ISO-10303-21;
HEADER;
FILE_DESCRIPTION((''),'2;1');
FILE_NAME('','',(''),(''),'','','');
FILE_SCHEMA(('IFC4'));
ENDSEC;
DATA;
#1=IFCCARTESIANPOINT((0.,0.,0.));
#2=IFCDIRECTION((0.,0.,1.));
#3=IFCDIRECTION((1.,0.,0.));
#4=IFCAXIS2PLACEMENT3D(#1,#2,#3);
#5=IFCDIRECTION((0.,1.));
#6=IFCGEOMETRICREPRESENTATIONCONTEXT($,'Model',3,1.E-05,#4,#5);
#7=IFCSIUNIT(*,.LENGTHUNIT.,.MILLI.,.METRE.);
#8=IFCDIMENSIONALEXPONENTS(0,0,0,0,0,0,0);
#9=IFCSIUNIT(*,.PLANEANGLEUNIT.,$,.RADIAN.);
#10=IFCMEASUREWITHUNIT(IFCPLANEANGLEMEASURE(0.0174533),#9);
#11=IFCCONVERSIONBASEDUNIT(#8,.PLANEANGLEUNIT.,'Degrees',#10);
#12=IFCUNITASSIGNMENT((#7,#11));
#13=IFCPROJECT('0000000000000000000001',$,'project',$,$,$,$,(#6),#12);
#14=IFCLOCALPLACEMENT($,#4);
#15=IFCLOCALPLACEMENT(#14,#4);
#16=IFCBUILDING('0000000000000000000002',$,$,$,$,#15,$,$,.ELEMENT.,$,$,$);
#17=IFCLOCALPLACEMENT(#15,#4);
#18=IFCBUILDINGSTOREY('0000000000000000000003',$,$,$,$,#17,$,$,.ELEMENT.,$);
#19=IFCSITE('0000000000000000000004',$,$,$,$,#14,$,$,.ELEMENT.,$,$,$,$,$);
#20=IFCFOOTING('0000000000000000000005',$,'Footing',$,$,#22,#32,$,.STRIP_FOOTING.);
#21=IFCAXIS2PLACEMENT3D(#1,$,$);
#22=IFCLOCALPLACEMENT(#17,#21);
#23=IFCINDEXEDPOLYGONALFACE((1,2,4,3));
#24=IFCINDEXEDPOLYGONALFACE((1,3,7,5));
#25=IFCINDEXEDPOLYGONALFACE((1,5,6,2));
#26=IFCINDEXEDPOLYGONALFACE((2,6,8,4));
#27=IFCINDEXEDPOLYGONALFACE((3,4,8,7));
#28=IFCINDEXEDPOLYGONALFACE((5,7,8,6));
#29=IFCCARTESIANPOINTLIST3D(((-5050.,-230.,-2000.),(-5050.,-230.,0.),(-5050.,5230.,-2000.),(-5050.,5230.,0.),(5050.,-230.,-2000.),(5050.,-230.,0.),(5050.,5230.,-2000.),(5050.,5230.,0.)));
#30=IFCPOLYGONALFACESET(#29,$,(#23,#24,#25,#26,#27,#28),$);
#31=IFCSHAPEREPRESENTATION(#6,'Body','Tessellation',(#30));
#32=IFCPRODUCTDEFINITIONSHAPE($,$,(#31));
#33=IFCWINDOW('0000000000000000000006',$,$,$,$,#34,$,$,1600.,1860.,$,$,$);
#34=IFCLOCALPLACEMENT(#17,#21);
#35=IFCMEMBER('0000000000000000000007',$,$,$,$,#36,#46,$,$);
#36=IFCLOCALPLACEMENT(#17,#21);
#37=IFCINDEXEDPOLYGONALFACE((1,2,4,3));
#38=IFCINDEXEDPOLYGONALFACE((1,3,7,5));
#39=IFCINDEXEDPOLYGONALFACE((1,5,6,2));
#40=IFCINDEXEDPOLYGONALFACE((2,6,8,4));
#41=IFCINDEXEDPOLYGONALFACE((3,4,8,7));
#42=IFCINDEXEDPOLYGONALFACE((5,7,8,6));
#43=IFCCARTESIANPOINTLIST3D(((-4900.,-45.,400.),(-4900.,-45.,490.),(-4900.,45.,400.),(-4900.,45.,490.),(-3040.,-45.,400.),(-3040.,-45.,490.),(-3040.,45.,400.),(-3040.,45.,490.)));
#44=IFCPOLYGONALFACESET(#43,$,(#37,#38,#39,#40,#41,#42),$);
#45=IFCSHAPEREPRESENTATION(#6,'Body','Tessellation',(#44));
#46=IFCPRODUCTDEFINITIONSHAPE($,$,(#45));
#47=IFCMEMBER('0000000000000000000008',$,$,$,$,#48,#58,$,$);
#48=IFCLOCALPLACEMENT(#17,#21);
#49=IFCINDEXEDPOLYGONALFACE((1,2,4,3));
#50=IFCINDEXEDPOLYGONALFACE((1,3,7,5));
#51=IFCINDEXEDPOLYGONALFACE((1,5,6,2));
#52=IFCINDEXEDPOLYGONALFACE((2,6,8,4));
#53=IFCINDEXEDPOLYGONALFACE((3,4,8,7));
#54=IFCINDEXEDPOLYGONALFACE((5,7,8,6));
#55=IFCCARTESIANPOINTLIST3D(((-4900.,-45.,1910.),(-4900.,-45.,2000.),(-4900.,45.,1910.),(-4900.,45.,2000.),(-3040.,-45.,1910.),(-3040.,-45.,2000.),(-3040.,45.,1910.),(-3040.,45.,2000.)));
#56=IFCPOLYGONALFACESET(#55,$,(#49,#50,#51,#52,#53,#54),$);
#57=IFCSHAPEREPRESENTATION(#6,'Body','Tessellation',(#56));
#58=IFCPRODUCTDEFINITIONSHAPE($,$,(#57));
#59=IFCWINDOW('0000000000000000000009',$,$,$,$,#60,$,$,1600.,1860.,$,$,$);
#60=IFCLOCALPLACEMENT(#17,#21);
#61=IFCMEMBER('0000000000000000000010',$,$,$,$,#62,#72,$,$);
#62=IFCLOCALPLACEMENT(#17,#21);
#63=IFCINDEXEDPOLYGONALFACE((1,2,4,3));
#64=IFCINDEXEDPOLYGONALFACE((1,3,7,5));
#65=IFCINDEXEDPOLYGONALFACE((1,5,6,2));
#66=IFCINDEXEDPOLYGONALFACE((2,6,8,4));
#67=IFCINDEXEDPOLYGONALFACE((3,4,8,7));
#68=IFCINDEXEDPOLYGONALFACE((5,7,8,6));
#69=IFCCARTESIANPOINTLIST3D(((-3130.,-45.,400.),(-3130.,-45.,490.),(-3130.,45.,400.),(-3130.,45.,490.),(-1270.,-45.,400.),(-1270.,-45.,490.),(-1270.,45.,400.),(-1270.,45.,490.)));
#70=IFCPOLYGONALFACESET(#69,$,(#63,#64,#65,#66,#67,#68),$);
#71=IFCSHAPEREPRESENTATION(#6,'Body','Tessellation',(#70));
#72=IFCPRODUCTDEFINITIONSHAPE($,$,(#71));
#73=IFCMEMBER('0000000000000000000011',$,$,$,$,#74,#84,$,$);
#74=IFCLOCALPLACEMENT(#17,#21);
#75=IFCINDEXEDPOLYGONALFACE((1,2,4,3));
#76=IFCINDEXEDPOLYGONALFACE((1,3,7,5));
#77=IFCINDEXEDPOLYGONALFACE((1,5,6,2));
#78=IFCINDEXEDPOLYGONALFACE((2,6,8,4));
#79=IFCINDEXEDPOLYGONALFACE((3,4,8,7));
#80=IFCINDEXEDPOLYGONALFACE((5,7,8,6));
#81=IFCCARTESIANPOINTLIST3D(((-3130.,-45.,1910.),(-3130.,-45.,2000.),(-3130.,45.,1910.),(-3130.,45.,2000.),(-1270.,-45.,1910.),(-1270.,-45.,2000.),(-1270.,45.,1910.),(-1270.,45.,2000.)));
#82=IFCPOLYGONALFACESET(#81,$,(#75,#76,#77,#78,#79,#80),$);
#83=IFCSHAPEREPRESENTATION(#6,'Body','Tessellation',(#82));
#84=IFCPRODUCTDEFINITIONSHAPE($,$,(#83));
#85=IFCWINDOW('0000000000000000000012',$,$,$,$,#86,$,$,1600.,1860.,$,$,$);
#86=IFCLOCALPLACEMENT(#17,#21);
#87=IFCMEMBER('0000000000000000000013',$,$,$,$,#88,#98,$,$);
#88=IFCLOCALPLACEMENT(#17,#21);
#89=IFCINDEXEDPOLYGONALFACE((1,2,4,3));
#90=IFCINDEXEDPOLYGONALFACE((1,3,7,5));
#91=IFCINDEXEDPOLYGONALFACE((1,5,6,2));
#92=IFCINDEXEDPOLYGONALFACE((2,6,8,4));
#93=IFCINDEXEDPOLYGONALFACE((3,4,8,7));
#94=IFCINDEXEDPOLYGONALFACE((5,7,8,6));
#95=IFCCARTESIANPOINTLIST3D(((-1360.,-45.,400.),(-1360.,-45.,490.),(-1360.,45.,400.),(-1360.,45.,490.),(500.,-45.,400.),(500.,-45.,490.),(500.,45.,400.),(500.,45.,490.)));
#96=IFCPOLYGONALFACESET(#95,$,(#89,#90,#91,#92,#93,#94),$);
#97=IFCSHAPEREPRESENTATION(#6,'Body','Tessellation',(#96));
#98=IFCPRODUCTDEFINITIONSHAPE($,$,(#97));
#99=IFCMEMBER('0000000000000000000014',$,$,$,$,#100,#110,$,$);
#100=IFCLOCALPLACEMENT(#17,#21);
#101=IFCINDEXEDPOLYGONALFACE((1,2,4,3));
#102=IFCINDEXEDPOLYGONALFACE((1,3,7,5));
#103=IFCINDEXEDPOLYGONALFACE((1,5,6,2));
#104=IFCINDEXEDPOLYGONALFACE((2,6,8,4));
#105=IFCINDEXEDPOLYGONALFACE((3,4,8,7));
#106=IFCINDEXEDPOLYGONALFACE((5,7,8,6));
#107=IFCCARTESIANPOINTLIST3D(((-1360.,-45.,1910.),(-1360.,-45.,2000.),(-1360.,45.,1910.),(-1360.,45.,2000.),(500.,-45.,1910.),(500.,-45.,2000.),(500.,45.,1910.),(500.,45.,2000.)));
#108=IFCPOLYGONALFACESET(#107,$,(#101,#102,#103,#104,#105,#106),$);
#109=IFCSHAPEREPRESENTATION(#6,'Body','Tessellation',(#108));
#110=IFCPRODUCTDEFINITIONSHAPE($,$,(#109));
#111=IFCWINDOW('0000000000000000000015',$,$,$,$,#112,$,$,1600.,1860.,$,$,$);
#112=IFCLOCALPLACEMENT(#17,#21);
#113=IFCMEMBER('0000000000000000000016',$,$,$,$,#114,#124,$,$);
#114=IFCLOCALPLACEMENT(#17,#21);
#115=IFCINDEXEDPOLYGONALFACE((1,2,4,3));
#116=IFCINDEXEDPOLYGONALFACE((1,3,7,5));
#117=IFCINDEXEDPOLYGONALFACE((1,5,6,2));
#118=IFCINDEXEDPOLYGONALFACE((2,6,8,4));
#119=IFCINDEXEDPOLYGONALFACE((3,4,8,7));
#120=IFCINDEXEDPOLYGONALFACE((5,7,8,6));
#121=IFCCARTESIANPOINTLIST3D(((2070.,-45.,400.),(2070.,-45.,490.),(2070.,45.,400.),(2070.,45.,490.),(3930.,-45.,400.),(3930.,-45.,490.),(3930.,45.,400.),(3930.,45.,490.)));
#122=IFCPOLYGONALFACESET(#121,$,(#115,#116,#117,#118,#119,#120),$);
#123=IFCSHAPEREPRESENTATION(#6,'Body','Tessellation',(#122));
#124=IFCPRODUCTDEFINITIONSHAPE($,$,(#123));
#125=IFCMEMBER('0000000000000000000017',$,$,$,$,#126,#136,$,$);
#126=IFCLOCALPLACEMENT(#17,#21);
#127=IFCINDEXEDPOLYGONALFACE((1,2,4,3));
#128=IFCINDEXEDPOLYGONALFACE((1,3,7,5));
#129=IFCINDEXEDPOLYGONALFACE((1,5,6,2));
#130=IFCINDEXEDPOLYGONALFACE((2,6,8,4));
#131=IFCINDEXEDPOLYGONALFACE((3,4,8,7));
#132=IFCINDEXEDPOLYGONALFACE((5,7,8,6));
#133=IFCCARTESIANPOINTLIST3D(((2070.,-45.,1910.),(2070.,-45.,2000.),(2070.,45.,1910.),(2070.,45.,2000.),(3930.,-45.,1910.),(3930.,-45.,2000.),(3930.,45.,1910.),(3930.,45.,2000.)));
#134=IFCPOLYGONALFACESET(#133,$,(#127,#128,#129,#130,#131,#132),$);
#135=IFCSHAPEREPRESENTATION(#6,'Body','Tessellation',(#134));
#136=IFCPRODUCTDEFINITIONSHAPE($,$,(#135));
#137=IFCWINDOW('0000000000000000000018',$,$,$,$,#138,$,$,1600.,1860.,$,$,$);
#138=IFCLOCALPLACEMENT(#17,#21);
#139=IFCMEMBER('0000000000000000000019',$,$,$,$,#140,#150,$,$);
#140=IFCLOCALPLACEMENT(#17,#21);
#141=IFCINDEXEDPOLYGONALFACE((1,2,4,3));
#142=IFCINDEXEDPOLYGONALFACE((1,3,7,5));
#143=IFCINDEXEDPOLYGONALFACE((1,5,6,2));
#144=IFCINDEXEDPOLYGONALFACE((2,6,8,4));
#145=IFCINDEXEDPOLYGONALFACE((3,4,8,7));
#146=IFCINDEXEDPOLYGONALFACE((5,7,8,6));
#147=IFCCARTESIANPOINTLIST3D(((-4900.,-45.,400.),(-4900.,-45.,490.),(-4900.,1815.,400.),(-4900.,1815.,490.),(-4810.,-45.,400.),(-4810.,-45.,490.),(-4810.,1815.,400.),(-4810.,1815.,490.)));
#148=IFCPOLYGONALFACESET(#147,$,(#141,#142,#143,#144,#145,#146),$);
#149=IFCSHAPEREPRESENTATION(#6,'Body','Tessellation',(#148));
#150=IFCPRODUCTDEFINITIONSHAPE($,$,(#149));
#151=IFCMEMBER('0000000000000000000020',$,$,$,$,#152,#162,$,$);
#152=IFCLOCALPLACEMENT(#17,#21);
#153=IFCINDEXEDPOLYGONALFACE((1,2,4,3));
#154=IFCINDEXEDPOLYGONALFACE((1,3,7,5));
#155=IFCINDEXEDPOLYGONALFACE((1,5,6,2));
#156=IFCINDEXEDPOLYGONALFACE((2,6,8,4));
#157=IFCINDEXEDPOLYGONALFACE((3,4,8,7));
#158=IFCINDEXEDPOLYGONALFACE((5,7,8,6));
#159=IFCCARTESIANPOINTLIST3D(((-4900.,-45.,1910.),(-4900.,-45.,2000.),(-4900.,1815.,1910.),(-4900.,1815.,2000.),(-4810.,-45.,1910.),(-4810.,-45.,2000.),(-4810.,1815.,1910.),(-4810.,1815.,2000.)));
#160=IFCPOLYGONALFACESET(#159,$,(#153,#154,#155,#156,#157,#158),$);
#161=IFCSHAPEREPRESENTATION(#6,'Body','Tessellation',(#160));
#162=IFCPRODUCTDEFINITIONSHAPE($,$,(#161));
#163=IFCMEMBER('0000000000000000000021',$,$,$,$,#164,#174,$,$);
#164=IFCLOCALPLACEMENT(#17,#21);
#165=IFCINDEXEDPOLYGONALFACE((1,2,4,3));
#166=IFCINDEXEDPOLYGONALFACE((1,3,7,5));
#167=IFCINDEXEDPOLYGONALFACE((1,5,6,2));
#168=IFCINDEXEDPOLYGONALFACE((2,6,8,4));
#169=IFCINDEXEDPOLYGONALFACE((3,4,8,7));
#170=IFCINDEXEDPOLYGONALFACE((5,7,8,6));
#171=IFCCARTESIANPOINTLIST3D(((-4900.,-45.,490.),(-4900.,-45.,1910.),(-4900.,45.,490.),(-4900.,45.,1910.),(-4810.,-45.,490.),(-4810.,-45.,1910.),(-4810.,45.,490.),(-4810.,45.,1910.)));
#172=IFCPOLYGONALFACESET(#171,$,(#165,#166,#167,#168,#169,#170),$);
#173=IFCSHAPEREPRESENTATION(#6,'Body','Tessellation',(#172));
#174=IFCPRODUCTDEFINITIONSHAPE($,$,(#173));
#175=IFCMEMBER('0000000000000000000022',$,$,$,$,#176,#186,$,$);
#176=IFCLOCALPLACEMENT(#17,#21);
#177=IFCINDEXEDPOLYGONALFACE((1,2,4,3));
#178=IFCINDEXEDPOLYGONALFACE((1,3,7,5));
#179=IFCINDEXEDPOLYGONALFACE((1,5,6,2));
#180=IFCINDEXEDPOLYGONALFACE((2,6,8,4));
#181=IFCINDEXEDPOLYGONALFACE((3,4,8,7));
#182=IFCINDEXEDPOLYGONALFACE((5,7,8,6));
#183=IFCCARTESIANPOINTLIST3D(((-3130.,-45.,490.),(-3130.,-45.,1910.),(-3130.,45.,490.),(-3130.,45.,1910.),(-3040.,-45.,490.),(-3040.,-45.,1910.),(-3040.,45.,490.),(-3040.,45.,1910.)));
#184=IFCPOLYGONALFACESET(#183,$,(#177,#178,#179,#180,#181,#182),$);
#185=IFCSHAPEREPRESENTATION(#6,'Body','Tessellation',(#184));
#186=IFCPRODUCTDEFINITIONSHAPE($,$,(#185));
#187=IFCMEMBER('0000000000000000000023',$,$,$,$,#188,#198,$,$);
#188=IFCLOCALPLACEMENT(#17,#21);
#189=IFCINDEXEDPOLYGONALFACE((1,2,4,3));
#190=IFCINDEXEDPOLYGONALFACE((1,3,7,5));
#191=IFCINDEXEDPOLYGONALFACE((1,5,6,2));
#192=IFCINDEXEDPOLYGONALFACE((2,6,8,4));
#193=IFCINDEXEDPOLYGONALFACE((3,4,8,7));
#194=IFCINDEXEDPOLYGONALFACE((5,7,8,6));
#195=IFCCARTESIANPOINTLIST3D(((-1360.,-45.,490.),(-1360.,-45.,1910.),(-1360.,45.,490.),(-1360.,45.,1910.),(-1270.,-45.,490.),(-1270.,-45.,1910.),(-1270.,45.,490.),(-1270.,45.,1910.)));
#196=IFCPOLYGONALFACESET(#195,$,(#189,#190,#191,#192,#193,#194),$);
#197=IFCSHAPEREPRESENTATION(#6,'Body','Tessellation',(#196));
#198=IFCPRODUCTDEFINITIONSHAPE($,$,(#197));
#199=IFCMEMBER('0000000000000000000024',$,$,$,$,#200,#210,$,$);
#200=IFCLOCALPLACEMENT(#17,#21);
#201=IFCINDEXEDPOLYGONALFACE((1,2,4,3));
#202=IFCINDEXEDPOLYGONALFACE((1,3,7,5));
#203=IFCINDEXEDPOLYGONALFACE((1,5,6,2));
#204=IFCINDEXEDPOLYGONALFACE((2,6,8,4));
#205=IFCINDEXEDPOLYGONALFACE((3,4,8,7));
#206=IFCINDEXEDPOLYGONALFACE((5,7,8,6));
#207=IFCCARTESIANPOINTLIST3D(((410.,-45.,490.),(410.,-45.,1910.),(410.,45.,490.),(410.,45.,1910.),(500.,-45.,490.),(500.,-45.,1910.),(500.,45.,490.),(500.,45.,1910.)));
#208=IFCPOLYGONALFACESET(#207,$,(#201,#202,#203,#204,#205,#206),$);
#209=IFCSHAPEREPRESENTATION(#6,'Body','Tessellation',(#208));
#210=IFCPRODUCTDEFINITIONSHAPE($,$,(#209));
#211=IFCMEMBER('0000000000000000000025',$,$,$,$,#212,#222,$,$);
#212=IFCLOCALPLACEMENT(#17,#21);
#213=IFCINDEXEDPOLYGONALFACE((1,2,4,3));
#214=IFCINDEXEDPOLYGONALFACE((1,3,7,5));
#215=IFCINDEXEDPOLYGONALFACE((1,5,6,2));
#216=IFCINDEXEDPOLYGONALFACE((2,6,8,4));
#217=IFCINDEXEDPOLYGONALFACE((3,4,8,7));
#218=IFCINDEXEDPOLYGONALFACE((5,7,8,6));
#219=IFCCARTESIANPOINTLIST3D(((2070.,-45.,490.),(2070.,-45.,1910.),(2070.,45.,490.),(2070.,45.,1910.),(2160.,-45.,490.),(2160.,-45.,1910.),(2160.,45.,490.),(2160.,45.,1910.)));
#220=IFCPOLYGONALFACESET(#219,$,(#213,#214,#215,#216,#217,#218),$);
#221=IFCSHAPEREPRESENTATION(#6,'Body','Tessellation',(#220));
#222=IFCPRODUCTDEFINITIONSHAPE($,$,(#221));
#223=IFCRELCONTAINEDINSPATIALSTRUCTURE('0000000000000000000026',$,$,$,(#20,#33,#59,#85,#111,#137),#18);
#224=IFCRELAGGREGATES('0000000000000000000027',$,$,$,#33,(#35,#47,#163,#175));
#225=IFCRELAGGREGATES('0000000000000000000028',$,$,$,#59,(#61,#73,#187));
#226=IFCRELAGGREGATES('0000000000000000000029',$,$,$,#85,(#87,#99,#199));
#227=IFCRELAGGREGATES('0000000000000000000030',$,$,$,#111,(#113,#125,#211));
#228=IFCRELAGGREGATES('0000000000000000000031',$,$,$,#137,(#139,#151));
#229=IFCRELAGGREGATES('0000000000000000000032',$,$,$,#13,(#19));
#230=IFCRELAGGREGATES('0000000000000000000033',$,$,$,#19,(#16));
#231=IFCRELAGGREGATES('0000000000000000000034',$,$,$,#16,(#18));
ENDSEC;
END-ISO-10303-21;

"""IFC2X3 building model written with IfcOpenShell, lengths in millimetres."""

from ifc_helpers import new_model, entity, si_unit, converted_unit, direction, frame, origin_with_axes, place, context, project, spatial, polyline, outline, extrude, source, transform, mapped, element, aggregate, save


model = new_model("IFC2X3")

# Units and contexts
model_context = context("Model", 3, precision=1e-05, world=origin_with_axes(), true_north=direction((0.0, 1.0)))
ifc_project = project(units=[si_unit("LENGTHUNIT", "METRE", prefix="MILLI"), converted_unit("PLANEANGLEUNIT", "Degrees", entity("IfcPlaneAngleMeasure", 0.0174533), si_unit("PLANEANGLEUNIT", "RADIAN"), dimensions=[0, 0, 0, 0, 0, 0, 0])], contexts=[model_context])

# Site, building, storey
site_placement = place(None, origin_with_axes())
site = spatial("IfcSite", under=ifc_project, at=site_placement, CompositionType="ELEMENT")
building_placement = place(site_placement, origin_with_axes())
building = spatial("IfcBuilding", under=site, at=building_placement, CompositionType="ELEMENT")
storey_placement = place(building_placement, origin_with_axes())
storey = spatial("IfcBuildingStorey", under=building, at=storey_placement, CompositionType="ELEMENT")

# Footing
footing_placement = place(storey_placement, frame((0.0, 2500.0, -2000.0), z_axis=(0.0, 0.0, 1.0), x_axis=(1.0, 0.0, 0.0)))
element("IfcFooting", 1, at=footing_placement, inside=storey, Name="Footing", PredefinedType="STRIP_FOOTING", context=model_context, shape_type="SweptSolid", body=[
    extrude(outline(polyline([(-5050.0, -2730.0), (5050.0, -2730.0), (5050.0, 2730.0), (-5050.0, 2730.0), (-5050.0, -2730.0), (-5050.0, -2730.0)])), origin_with_axes(), (0.0, 0.0, 1.0), 2000.0),
])

# Windows, members
window_1_placement = place(storey_placement, frame((-4900.0, -45.0, 400.0), z_axis=(0.0, 0.0, 1.0), x_axis=(1.0, 0.0, 0.0)))
window_1 = element("IfcWindow", 2, at=window_1_placement, inside=storey, OverallHeight=1600.0, OverallWidth=1860.0)
shared_shape_1 = source(origin_with_axes(), model_context, "Body", "SweptSolid", [
    extrude(outline(polyline([(-930.0, -45.0), (930.0, -45.0), (930.0, 45.0), (-930.0, 45.0), (-930.0, -45.0), (-930.0, -45.0)])), origin_with_axes(), (0.0, 0.0, 1.0), 90.0),
])
member_1_placement = place(window_1_placement, frame((930.0, 45.0, 0.0), z_axis=(0.0, 0.0, 1.0), x_axis=(1.0, 0.0, 0.0)))
member_1 = element("IfcMember", 3, at=member_1_placement, context=model_context, shape_type="MappedRepresentation", body=[
    mapped(shared_shape_1, transform((0.0, 0.0, 0.0))),
])
member_2_placement = place(window_1_placement, frame((930.0, 45.0, 1510.0), z_axis=(0.0, 0.0, 1.0), x_axis=(1.0, 0.0, 0.0)))
member_2 = element("IfcMember", 4, at=member_2_placement, context=model_context, shape_type="MappedRepresentation", body=[
    mapped(shared_shape_1, transform((0.0, 0.0, 0.0))),
])
window_2_placement = place(storey_placement, frame((-3130.0, -45.0, 400.0), z_axis=(0.0, 0.0, 1.0), x_axis=(1.0, 0.0, 0.0)))
window_2 = element("IfcWindow", 5, at=window_2_placement, inside=storey, OverallHeight=1600.0, OverallWidth=1860.0)
member_3_placement = place(window_2_placement, frame((930.0, 45.0, 0.0), z_axis=(0.0, 0.0, 1.0), x_axis=(1.0, 0.0, 0.0)))
member_3 = element("IfcMember", 6, at=member_3_placement, context=model_context, shape_type="MappedRepresentation", body=[
    mapped(shared_shape_1, transform((0.0, 0.0, 0.0))),
])
member_4_placement = place(window_2_placement, frame((930.0, 45.0, 1510.0), z_axis=(0.0, 0.0, 1.0), x_axis=(1.0, 0.0, 0.0)))
member_4 = element("IfcMember", 7, at=member_4_placement, context=model_context, shape_type="MappedRepresentation", body=[
    mapped(shared_shape_1, transform((0.0, 0.0, 0.0))),
])
window_3_placement = place(storey_placement, frame((-1360.0, -45.0, 400.0), z_axis=(0.0, 0.0, 1.0), x_axis=(1.0, 0.0, 0.0)))
window_3 = element("IfcWindow", 8, at=window_3_placement, inside=storey, OverallHeight=1600.0, OverallWidth=1860.0)
member_5_placement = place(window_3_placement, frame((930.0, 45.0, 0.0), z_axis=(0.0, 0.0, 1.0), x_axis=(1.0, 0.0, 0.0)))
member_5 = element("IfcMember", 9, at=member_5_placement, context=model_context, shape_type="MappedRepresentation", body=[
    mapped(shared_shape_1, transform((0.0, 0.0, 0.0))),
])
member_6_placement = place(window_3_placement, frame((930.0, 45.0, 1510.0), z_axis=(0.0, 0.0, 1.0), x_axis=(1.0, 0.0, 0.0)))
member_6 = element("IfcMember", 10, at=member_6_placement, context=model_context, shape_type="MappedRepresentation", body=[
    mapped(shared_shape_1, transform((0.0, 0.0, 0.0))),
])
window_4_placement = place(storey_placement, frame((2070.0, -45.0, 400.0), z_axis=(0.0, 0.0, 1.0), x_axis=(1.0, 0.0, 0.0)))
window_4 = element("IfcWindow", 11, at=window_4_placement, inside=storey, OverallHeight=1600.0, OverallWidth=1860.0)
member_7_placement = place(window_4_placement, frame((930.0, 45.0, 0.0), z_axis=(0.0, 0.0, 1.0), x_axis=(1.0, 0.0, 0.0)))
member_7 = element("IfcMember", 12, at=member_7_placement, context=model_context, shape_type="MappedRepresentation", body=[
    mapped(shared_shape_1, transform((0.0, 0.0, 0.0))),
])
member_8_placement = place(window_4_placement, frame((930.0, 45.0, 1510.0), z_axis=(0.0, 0.0, 1.0), x_axis=(1.0, 0.0, 0.0)))
member_8 = element("IfcMember", 13, at=member_8_placement, context=model_context, shape_type="MappedRepresentation", body=[
    mapped(shared_shape_1, transform((0.0, 0.0, 0.0))),
])
window_5_placement = place(storey_placement, frame((-4810.0, -45.0, 400.0), z_axis=(0.0, 0.0, 1.0), x_axis=(0.0, 1.0, 0.0)))
window_5 = element("IfcWindow", 14, at=window_5_placement, inside=storey, OverallHeight=1600.0, OverallWidth=1860.0)
member_9_placement = place(window_5_placement, frame((930.0, 45.0, 0.0), z_axis=(0.0, 0.0, 1.0), x_axis=(1.0, 0.0, 0.0)))
member_9 = element("IfcMember", 15, at=member_9_placement, context=model_context, shape_type="MappedRepresentation", body=[
    mapped(shared_shape_1, transform((0.0, 0.0, 0.0))),
])
member_10_placement = place(window_5_placement, frame((930.0, 45.0, 1510.0), z_axis=(0.0, 0.0, 1.0), x_axis=(1.0, 0.0, 0.0)))
member_10 = element("IfcMember", 16, at=member_10_placement, context=model_context, shape_type="MappedRepresentation", body=[
    mapped(shared_shape_1, transform((0.0, 0.0, 0.0))),
])

# Members
shared_shape_2 = source(origin_with_axes(), model_context, "Body", "SweptSolid", [
    extrude(outline(polyline([(-45.0, -45.0), (45.0, -45.0), (45.0, 45.0), (-45.0, 45.0), (-45.0, -45.0), (-45.0, -45.0)])), origin_with_axes(), (0.0, 0.0, 1.0), 1420.0),
])
member_11_placement = place(window_1_placement, frame((45.0, 45.0, 90.0), z_axis=(0.0, 0.0, 1.0), x_axis=(1.0, 0.0, 0.0)))
member_11 = element("IfcMember", 17, at=member_11_placement, context=model_context, shape_type="MappedRepresentation", body=[
    mapped(shared_shape_2, transform((0.0, 0.0, 0.0))),
])
member_12_placement = place(window_1_placement, frame((1815.0, 45.0, 90.0), z_axis=(0.0, 0.0, 1.0), x_axis=(1.0, 0.0, 0.0)))
member_12 = element("IfcMember", 18, at=member_12_placement, context=model_context, shape_type="MappedRepresentation", body=[
    mapped(shared_shape_2, transform((0.0, 0.0, 0.0))),
])
member_13_placement = place(window_2_placement, frame((1815.0, 45.0, 90.0), z_axis=(0.0, 0.0, 1.0), x_axis=(1.0, 0.0, 0.0)))
member_13 = element("IfcMember", 19, at=member_13_placement, context=model_context, shape_type="MappedRepresentation", body=[
    mapped(shared_shape_2, transform((0.0, 0.0, 0.0))),
])
member_14_placement = place(window_3_placement, frame((1815.0, 45.0, 90.0), z_axis=(0.0, 0.0, 1.0), x_axis=(1.0, 0.0, 0.0)))
member_14 = element("IfcMember", 20, at=member_14_placement, context=model_context, shape_type="MappedRepresentation", body=[
    mapped(shared_shape_2, transform((0.0, 0.0, 0.0))),
])
member_15_placement = place(window_4_placement, frame((45.0, 45.0, 90.0), z_axis=(0.0, 0.0, 1.0), x_axis=(1.0, 0.0, 0.0)))
member_15 = element("IfcMember", 21, at=member_15_placement, context=model_context, shape_type="MappedRepresentation", body=[
    mapped(shared_shape_2, transform((0.0, 0.0, 0.0))),
])

aggregate(window_1, [member_1, member_2, member_11, member_12])
aggregate(window_2, [member_3, member_4, member_13])
aggregate(window_3, [member_5, member_6, member_14])
aggregate(window_4, [member_7, member_8, member_15])
aggregate(window_5, [member_9, member_10])

save(model, "model.ifc")
